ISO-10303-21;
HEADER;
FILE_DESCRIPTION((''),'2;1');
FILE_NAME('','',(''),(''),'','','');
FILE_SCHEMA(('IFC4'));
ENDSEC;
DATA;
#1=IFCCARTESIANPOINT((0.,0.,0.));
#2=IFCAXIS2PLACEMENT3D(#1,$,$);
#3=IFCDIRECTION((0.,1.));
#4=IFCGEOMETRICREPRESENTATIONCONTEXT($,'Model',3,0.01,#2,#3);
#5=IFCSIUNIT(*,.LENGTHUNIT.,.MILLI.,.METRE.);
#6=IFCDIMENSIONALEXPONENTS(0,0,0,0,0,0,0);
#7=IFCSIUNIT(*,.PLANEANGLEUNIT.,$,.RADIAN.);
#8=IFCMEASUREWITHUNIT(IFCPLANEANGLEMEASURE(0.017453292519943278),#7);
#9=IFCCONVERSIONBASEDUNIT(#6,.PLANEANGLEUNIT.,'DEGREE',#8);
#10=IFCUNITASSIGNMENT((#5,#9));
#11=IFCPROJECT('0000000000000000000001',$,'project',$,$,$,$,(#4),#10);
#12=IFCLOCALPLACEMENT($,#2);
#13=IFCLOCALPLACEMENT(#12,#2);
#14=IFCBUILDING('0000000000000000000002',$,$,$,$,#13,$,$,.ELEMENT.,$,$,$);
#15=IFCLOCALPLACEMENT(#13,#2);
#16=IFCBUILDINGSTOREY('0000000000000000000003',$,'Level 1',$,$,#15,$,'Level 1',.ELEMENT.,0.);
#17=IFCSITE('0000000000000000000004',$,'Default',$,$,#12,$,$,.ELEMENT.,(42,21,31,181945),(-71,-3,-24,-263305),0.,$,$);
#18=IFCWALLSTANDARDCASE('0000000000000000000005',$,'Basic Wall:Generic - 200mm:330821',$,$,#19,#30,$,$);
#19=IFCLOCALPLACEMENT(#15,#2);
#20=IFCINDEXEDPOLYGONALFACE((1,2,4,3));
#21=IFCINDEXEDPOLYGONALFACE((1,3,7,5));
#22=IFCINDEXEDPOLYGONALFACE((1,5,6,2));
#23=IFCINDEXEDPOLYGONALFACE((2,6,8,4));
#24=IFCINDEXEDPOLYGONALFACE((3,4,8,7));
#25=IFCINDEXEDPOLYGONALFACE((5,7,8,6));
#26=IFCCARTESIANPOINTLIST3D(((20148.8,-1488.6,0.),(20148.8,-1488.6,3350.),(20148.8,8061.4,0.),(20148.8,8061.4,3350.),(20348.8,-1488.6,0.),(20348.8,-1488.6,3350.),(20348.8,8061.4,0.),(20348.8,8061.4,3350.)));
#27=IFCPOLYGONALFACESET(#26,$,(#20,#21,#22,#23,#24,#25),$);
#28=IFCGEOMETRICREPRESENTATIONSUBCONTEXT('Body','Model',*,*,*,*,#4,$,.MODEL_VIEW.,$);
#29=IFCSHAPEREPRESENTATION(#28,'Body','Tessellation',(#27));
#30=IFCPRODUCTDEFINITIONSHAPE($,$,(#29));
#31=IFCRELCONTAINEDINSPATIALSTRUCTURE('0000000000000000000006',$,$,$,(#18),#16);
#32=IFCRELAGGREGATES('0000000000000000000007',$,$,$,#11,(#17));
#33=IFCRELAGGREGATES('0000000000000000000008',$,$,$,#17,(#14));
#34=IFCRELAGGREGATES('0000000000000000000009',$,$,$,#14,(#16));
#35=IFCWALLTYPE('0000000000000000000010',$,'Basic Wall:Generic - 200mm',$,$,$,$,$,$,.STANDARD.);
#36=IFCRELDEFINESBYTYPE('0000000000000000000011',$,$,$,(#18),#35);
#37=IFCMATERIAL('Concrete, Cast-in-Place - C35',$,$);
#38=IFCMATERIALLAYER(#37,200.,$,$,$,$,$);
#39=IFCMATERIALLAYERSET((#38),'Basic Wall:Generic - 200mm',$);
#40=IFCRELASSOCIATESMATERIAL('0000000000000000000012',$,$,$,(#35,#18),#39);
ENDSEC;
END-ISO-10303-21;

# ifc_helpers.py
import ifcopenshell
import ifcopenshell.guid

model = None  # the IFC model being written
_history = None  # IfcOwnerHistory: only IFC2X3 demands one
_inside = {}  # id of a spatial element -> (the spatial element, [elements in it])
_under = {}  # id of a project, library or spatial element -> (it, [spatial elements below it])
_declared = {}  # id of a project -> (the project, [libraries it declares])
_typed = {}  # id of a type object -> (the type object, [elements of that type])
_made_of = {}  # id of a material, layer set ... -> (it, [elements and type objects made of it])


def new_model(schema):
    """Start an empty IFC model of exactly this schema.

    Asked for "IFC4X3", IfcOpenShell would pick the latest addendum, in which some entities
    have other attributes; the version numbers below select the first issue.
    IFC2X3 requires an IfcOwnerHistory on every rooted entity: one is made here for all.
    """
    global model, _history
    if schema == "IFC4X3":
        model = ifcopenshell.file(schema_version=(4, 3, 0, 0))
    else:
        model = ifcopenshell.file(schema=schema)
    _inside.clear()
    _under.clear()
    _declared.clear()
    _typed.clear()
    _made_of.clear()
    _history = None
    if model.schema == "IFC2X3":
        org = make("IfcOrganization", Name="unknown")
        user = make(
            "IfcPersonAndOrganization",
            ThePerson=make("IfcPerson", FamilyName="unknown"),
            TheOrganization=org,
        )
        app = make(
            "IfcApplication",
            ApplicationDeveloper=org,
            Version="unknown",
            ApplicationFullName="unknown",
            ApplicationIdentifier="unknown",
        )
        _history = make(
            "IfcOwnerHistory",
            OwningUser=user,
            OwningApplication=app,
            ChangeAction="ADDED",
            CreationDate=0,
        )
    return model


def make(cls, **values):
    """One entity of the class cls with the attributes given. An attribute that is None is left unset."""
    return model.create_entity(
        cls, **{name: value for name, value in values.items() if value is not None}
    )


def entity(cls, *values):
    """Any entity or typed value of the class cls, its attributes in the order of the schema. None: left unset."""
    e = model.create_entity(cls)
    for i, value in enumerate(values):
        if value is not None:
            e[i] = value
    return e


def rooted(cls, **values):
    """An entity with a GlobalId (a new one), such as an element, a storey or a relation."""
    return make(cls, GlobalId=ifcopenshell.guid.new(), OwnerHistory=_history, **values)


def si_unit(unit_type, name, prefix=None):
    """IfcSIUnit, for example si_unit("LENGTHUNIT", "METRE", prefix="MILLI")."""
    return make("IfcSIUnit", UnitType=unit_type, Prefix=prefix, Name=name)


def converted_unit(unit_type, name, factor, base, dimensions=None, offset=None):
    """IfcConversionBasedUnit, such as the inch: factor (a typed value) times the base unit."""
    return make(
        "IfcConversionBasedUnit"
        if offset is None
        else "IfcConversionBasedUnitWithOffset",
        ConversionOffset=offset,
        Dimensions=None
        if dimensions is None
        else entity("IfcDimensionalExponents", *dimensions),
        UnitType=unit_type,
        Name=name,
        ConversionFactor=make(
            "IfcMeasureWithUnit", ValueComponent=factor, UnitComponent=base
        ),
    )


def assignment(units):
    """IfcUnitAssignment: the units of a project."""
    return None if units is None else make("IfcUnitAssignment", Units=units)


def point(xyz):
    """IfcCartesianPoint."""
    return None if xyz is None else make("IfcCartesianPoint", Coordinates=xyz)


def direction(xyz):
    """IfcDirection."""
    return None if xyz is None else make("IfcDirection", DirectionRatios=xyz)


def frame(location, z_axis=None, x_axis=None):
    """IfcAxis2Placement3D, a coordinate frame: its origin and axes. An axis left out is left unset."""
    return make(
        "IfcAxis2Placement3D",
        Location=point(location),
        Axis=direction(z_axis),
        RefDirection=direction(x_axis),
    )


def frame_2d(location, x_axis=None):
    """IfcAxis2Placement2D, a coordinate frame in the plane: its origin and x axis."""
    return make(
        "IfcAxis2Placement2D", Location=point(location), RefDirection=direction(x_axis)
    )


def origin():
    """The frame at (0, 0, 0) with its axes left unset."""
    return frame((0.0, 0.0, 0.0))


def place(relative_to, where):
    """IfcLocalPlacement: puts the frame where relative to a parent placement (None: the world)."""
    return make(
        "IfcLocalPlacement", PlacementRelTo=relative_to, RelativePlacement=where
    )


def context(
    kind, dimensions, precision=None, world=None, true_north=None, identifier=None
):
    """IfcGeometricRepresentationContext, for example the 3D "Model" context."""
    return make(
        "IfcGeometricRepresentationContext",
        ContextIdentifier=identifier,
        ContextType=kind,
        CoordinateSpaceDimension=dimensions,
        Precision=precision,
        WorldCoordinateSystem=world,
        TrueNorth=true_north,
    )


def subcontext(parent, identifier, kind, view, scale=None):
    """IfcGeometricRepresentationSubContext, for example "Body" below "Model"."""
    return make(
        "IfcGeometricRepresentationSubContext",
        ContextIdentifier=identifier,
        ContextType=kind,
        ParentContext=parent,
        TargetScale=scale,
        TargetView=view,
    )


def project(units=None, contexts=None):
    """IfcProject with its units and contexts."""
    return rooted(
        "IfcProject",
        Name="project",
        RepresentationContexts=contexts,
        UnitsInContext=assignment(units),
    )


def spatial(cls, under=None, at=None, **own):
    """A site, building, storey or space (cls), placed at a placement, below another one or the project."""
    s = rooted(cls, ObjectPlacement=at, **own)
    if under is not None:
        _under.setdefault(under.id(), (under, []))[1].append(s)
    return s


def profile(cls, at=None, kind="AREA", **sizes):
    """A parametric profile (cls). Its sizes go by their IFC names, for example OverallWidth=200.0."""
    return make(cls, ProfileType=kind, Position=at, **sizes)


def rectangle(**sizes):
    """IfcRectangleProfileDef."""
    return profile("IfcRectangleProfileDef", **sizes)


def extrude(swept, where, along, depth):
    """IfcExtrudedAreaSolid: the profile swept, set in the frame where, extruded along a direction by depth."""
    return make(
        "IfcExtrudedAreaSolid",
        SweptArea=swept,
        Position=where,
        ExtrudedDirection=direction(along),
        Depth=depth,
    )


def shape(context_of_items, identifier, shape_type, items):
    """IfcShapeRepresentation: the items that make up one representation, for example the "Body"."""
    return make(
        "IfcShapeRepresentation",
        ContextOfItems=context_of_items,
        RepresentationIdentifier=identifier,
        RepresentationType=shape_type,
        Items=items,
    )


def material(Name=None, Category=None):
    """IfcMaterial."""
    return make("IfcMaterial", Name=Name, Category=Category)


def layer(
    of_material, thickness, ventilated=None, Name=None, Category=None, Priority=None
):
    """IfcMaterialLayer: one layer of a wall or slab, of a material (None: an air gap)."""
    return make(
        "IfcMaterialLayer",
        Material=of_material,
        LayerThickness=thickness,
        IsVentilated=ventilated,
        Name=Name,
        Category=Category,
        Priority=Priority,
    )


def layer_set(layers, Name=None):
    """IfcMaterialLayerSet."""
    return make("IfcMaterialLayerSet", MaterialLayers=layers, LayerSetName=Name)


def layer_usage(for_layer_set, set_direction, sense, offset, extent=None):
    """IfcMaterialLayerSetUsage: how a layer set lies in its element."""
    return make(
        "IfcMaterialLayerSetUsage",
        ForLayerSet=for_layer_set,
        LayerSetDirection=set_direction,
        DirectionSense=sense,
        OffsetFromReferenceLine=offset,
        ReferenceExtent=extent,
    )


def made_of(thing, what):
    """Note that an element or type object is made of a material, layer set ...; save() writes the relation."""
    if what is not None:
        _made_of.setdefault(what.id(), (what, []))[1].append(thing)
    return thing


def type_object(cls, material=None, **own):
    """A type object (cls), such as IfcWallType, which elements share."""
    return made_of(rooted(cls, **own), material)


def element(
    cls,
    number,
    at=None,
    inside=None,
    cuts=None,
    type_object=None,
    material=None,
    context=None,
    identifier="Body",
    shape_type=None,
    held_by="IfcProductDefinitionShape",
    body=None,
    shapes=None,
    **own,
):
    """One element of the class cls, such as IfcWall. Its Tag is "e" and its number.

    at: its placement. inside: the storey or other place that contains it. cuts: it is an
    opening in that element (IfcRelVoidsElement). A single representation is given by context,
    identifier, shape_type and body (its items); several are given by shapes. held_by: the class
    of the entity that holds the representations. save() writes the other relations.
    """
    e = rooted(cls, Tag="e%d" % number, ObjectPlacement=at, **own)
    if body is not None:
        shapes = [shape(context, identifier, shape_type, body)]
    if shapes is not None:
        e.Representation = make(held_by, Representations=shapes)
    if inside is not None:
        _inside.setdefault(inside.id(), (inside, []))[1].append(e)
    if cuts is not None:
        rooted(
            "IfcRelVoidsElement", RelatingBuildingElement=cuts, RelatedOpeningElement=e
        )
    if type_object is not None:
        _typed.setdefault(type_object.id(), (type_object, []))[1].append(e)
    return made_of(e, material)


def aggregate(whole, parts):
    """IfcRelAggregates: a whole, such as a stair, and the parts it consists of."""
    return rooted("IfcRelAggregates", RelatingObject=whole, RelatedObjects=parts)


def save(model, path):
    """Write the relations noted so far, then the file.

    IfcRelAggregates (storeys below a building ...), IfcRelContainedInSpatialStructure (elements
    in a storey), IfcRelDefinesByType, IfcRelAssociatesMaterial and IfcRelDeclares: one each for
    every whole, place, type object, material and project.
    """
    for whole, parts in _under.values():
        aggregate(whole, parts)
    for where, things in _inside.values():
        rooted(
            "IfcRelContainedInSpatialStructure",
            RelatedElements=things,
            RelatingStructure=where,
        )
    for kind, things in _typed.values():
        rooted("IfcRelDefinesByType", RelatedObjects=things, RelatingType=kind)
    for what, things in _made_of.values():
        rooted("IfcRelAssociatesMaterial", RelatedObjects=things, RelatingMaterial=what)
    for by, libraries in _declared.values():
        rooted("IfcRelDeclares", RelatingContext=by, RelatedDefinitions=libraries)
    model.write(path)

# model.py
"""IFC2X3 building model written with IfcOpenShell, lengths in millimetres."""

from ifc_helpers import new_model, entity, si_unit, converted_unit, direction, frame, frame_2d, origin, place, context, subcontext, project, spatial, rectangle, extrude, material, layer, layer_set, layer_usage, type_object, element, save


model = new_model("IFC2X3")

# Units and contexts
model_context = context("Model", 3, precision=0.01, world=origin(), true_north=direction((0.0, 1.0)))
body_context = subcontext(model_context, "Body", "Model", "MODEL_VIEW")
ifc_project = project(units=[si_unit("LENGTHUNIT", "METRE", prefix="MILLI"), converted_unit("PLANEANGLEUNIT", "DEGREE", entity("IfcPlaneAngleMeasure", 0.017453292519943278), si_unit("PLANEANGLEUNIT", "RADIAN"), dimensions=[0, 0, 0, 0, 0, 0, 0])], contexts=[model_context])

# Site, building, storey
site_placement = place(None, origin())
site = spatial("IfcSite", under=ifc_project, at=site_placement, Name="Default", CompositionType="ELEMENT", RefLatitude=(42, 21, 31, 181945), RefLongitude=(-71, -3, -24, -263305), RefElevation=0.0)
building_placement = place(site_placement, origin())
building = spatial("IfcBuilding", under=site, at=building_placement, CompositionType="ELEMENT")
storey_placement = place(building_placement, origin())
storey = spatial("IfcBuildingStorey", under=building, at=storey_placement, Name="Level 1", LongName="Level 1", CompositionType="ELEMENT", Elevation=0.0)

# Shared definitions
ifc_material = material(Name="Concrete, Cast-in-Place - C35")

# Wall
ifc_layer = layer(ifc_material, 200.0)
ifc_layer_set = layer_set([ifc_layer], Name="Basic Wall:Generic - 200mm")
ifc_layer_usage = layer_usage(ifc_layer_set, "AXIS2", "NEGATIVE", 100.0)
wall_type = type_object("IfcWallType", Name="Basic Wall:Generic - 200mm", PredefinedType="STANDARD", material=ifc_layer_set)
wall_placement = place(storey_placement, frame((20248.8, -1488.6, 0.0), z_axis=(0.0, 0.0, 1.0), x_axis=(0.0, 1.0, 0.0)))
element("IfcWallStandardCase", 1, at=wall_placement, inside=storey, type_object=wall_type, material=ifc_layer_usage, Name="Basic Wall:Generic - 200mm:330821", context=body_context, shape_type="SweptSolid", body=[
    extrude(rectangle(XDim=9550.0, YDim=200.0, at=frame_2d((4775.0, 0.0), x_axis=(-1.0, 0.0))), origin(), (0.0, 0.0, 1.0), 3350.0),
])

save(model, "model.ifc")
